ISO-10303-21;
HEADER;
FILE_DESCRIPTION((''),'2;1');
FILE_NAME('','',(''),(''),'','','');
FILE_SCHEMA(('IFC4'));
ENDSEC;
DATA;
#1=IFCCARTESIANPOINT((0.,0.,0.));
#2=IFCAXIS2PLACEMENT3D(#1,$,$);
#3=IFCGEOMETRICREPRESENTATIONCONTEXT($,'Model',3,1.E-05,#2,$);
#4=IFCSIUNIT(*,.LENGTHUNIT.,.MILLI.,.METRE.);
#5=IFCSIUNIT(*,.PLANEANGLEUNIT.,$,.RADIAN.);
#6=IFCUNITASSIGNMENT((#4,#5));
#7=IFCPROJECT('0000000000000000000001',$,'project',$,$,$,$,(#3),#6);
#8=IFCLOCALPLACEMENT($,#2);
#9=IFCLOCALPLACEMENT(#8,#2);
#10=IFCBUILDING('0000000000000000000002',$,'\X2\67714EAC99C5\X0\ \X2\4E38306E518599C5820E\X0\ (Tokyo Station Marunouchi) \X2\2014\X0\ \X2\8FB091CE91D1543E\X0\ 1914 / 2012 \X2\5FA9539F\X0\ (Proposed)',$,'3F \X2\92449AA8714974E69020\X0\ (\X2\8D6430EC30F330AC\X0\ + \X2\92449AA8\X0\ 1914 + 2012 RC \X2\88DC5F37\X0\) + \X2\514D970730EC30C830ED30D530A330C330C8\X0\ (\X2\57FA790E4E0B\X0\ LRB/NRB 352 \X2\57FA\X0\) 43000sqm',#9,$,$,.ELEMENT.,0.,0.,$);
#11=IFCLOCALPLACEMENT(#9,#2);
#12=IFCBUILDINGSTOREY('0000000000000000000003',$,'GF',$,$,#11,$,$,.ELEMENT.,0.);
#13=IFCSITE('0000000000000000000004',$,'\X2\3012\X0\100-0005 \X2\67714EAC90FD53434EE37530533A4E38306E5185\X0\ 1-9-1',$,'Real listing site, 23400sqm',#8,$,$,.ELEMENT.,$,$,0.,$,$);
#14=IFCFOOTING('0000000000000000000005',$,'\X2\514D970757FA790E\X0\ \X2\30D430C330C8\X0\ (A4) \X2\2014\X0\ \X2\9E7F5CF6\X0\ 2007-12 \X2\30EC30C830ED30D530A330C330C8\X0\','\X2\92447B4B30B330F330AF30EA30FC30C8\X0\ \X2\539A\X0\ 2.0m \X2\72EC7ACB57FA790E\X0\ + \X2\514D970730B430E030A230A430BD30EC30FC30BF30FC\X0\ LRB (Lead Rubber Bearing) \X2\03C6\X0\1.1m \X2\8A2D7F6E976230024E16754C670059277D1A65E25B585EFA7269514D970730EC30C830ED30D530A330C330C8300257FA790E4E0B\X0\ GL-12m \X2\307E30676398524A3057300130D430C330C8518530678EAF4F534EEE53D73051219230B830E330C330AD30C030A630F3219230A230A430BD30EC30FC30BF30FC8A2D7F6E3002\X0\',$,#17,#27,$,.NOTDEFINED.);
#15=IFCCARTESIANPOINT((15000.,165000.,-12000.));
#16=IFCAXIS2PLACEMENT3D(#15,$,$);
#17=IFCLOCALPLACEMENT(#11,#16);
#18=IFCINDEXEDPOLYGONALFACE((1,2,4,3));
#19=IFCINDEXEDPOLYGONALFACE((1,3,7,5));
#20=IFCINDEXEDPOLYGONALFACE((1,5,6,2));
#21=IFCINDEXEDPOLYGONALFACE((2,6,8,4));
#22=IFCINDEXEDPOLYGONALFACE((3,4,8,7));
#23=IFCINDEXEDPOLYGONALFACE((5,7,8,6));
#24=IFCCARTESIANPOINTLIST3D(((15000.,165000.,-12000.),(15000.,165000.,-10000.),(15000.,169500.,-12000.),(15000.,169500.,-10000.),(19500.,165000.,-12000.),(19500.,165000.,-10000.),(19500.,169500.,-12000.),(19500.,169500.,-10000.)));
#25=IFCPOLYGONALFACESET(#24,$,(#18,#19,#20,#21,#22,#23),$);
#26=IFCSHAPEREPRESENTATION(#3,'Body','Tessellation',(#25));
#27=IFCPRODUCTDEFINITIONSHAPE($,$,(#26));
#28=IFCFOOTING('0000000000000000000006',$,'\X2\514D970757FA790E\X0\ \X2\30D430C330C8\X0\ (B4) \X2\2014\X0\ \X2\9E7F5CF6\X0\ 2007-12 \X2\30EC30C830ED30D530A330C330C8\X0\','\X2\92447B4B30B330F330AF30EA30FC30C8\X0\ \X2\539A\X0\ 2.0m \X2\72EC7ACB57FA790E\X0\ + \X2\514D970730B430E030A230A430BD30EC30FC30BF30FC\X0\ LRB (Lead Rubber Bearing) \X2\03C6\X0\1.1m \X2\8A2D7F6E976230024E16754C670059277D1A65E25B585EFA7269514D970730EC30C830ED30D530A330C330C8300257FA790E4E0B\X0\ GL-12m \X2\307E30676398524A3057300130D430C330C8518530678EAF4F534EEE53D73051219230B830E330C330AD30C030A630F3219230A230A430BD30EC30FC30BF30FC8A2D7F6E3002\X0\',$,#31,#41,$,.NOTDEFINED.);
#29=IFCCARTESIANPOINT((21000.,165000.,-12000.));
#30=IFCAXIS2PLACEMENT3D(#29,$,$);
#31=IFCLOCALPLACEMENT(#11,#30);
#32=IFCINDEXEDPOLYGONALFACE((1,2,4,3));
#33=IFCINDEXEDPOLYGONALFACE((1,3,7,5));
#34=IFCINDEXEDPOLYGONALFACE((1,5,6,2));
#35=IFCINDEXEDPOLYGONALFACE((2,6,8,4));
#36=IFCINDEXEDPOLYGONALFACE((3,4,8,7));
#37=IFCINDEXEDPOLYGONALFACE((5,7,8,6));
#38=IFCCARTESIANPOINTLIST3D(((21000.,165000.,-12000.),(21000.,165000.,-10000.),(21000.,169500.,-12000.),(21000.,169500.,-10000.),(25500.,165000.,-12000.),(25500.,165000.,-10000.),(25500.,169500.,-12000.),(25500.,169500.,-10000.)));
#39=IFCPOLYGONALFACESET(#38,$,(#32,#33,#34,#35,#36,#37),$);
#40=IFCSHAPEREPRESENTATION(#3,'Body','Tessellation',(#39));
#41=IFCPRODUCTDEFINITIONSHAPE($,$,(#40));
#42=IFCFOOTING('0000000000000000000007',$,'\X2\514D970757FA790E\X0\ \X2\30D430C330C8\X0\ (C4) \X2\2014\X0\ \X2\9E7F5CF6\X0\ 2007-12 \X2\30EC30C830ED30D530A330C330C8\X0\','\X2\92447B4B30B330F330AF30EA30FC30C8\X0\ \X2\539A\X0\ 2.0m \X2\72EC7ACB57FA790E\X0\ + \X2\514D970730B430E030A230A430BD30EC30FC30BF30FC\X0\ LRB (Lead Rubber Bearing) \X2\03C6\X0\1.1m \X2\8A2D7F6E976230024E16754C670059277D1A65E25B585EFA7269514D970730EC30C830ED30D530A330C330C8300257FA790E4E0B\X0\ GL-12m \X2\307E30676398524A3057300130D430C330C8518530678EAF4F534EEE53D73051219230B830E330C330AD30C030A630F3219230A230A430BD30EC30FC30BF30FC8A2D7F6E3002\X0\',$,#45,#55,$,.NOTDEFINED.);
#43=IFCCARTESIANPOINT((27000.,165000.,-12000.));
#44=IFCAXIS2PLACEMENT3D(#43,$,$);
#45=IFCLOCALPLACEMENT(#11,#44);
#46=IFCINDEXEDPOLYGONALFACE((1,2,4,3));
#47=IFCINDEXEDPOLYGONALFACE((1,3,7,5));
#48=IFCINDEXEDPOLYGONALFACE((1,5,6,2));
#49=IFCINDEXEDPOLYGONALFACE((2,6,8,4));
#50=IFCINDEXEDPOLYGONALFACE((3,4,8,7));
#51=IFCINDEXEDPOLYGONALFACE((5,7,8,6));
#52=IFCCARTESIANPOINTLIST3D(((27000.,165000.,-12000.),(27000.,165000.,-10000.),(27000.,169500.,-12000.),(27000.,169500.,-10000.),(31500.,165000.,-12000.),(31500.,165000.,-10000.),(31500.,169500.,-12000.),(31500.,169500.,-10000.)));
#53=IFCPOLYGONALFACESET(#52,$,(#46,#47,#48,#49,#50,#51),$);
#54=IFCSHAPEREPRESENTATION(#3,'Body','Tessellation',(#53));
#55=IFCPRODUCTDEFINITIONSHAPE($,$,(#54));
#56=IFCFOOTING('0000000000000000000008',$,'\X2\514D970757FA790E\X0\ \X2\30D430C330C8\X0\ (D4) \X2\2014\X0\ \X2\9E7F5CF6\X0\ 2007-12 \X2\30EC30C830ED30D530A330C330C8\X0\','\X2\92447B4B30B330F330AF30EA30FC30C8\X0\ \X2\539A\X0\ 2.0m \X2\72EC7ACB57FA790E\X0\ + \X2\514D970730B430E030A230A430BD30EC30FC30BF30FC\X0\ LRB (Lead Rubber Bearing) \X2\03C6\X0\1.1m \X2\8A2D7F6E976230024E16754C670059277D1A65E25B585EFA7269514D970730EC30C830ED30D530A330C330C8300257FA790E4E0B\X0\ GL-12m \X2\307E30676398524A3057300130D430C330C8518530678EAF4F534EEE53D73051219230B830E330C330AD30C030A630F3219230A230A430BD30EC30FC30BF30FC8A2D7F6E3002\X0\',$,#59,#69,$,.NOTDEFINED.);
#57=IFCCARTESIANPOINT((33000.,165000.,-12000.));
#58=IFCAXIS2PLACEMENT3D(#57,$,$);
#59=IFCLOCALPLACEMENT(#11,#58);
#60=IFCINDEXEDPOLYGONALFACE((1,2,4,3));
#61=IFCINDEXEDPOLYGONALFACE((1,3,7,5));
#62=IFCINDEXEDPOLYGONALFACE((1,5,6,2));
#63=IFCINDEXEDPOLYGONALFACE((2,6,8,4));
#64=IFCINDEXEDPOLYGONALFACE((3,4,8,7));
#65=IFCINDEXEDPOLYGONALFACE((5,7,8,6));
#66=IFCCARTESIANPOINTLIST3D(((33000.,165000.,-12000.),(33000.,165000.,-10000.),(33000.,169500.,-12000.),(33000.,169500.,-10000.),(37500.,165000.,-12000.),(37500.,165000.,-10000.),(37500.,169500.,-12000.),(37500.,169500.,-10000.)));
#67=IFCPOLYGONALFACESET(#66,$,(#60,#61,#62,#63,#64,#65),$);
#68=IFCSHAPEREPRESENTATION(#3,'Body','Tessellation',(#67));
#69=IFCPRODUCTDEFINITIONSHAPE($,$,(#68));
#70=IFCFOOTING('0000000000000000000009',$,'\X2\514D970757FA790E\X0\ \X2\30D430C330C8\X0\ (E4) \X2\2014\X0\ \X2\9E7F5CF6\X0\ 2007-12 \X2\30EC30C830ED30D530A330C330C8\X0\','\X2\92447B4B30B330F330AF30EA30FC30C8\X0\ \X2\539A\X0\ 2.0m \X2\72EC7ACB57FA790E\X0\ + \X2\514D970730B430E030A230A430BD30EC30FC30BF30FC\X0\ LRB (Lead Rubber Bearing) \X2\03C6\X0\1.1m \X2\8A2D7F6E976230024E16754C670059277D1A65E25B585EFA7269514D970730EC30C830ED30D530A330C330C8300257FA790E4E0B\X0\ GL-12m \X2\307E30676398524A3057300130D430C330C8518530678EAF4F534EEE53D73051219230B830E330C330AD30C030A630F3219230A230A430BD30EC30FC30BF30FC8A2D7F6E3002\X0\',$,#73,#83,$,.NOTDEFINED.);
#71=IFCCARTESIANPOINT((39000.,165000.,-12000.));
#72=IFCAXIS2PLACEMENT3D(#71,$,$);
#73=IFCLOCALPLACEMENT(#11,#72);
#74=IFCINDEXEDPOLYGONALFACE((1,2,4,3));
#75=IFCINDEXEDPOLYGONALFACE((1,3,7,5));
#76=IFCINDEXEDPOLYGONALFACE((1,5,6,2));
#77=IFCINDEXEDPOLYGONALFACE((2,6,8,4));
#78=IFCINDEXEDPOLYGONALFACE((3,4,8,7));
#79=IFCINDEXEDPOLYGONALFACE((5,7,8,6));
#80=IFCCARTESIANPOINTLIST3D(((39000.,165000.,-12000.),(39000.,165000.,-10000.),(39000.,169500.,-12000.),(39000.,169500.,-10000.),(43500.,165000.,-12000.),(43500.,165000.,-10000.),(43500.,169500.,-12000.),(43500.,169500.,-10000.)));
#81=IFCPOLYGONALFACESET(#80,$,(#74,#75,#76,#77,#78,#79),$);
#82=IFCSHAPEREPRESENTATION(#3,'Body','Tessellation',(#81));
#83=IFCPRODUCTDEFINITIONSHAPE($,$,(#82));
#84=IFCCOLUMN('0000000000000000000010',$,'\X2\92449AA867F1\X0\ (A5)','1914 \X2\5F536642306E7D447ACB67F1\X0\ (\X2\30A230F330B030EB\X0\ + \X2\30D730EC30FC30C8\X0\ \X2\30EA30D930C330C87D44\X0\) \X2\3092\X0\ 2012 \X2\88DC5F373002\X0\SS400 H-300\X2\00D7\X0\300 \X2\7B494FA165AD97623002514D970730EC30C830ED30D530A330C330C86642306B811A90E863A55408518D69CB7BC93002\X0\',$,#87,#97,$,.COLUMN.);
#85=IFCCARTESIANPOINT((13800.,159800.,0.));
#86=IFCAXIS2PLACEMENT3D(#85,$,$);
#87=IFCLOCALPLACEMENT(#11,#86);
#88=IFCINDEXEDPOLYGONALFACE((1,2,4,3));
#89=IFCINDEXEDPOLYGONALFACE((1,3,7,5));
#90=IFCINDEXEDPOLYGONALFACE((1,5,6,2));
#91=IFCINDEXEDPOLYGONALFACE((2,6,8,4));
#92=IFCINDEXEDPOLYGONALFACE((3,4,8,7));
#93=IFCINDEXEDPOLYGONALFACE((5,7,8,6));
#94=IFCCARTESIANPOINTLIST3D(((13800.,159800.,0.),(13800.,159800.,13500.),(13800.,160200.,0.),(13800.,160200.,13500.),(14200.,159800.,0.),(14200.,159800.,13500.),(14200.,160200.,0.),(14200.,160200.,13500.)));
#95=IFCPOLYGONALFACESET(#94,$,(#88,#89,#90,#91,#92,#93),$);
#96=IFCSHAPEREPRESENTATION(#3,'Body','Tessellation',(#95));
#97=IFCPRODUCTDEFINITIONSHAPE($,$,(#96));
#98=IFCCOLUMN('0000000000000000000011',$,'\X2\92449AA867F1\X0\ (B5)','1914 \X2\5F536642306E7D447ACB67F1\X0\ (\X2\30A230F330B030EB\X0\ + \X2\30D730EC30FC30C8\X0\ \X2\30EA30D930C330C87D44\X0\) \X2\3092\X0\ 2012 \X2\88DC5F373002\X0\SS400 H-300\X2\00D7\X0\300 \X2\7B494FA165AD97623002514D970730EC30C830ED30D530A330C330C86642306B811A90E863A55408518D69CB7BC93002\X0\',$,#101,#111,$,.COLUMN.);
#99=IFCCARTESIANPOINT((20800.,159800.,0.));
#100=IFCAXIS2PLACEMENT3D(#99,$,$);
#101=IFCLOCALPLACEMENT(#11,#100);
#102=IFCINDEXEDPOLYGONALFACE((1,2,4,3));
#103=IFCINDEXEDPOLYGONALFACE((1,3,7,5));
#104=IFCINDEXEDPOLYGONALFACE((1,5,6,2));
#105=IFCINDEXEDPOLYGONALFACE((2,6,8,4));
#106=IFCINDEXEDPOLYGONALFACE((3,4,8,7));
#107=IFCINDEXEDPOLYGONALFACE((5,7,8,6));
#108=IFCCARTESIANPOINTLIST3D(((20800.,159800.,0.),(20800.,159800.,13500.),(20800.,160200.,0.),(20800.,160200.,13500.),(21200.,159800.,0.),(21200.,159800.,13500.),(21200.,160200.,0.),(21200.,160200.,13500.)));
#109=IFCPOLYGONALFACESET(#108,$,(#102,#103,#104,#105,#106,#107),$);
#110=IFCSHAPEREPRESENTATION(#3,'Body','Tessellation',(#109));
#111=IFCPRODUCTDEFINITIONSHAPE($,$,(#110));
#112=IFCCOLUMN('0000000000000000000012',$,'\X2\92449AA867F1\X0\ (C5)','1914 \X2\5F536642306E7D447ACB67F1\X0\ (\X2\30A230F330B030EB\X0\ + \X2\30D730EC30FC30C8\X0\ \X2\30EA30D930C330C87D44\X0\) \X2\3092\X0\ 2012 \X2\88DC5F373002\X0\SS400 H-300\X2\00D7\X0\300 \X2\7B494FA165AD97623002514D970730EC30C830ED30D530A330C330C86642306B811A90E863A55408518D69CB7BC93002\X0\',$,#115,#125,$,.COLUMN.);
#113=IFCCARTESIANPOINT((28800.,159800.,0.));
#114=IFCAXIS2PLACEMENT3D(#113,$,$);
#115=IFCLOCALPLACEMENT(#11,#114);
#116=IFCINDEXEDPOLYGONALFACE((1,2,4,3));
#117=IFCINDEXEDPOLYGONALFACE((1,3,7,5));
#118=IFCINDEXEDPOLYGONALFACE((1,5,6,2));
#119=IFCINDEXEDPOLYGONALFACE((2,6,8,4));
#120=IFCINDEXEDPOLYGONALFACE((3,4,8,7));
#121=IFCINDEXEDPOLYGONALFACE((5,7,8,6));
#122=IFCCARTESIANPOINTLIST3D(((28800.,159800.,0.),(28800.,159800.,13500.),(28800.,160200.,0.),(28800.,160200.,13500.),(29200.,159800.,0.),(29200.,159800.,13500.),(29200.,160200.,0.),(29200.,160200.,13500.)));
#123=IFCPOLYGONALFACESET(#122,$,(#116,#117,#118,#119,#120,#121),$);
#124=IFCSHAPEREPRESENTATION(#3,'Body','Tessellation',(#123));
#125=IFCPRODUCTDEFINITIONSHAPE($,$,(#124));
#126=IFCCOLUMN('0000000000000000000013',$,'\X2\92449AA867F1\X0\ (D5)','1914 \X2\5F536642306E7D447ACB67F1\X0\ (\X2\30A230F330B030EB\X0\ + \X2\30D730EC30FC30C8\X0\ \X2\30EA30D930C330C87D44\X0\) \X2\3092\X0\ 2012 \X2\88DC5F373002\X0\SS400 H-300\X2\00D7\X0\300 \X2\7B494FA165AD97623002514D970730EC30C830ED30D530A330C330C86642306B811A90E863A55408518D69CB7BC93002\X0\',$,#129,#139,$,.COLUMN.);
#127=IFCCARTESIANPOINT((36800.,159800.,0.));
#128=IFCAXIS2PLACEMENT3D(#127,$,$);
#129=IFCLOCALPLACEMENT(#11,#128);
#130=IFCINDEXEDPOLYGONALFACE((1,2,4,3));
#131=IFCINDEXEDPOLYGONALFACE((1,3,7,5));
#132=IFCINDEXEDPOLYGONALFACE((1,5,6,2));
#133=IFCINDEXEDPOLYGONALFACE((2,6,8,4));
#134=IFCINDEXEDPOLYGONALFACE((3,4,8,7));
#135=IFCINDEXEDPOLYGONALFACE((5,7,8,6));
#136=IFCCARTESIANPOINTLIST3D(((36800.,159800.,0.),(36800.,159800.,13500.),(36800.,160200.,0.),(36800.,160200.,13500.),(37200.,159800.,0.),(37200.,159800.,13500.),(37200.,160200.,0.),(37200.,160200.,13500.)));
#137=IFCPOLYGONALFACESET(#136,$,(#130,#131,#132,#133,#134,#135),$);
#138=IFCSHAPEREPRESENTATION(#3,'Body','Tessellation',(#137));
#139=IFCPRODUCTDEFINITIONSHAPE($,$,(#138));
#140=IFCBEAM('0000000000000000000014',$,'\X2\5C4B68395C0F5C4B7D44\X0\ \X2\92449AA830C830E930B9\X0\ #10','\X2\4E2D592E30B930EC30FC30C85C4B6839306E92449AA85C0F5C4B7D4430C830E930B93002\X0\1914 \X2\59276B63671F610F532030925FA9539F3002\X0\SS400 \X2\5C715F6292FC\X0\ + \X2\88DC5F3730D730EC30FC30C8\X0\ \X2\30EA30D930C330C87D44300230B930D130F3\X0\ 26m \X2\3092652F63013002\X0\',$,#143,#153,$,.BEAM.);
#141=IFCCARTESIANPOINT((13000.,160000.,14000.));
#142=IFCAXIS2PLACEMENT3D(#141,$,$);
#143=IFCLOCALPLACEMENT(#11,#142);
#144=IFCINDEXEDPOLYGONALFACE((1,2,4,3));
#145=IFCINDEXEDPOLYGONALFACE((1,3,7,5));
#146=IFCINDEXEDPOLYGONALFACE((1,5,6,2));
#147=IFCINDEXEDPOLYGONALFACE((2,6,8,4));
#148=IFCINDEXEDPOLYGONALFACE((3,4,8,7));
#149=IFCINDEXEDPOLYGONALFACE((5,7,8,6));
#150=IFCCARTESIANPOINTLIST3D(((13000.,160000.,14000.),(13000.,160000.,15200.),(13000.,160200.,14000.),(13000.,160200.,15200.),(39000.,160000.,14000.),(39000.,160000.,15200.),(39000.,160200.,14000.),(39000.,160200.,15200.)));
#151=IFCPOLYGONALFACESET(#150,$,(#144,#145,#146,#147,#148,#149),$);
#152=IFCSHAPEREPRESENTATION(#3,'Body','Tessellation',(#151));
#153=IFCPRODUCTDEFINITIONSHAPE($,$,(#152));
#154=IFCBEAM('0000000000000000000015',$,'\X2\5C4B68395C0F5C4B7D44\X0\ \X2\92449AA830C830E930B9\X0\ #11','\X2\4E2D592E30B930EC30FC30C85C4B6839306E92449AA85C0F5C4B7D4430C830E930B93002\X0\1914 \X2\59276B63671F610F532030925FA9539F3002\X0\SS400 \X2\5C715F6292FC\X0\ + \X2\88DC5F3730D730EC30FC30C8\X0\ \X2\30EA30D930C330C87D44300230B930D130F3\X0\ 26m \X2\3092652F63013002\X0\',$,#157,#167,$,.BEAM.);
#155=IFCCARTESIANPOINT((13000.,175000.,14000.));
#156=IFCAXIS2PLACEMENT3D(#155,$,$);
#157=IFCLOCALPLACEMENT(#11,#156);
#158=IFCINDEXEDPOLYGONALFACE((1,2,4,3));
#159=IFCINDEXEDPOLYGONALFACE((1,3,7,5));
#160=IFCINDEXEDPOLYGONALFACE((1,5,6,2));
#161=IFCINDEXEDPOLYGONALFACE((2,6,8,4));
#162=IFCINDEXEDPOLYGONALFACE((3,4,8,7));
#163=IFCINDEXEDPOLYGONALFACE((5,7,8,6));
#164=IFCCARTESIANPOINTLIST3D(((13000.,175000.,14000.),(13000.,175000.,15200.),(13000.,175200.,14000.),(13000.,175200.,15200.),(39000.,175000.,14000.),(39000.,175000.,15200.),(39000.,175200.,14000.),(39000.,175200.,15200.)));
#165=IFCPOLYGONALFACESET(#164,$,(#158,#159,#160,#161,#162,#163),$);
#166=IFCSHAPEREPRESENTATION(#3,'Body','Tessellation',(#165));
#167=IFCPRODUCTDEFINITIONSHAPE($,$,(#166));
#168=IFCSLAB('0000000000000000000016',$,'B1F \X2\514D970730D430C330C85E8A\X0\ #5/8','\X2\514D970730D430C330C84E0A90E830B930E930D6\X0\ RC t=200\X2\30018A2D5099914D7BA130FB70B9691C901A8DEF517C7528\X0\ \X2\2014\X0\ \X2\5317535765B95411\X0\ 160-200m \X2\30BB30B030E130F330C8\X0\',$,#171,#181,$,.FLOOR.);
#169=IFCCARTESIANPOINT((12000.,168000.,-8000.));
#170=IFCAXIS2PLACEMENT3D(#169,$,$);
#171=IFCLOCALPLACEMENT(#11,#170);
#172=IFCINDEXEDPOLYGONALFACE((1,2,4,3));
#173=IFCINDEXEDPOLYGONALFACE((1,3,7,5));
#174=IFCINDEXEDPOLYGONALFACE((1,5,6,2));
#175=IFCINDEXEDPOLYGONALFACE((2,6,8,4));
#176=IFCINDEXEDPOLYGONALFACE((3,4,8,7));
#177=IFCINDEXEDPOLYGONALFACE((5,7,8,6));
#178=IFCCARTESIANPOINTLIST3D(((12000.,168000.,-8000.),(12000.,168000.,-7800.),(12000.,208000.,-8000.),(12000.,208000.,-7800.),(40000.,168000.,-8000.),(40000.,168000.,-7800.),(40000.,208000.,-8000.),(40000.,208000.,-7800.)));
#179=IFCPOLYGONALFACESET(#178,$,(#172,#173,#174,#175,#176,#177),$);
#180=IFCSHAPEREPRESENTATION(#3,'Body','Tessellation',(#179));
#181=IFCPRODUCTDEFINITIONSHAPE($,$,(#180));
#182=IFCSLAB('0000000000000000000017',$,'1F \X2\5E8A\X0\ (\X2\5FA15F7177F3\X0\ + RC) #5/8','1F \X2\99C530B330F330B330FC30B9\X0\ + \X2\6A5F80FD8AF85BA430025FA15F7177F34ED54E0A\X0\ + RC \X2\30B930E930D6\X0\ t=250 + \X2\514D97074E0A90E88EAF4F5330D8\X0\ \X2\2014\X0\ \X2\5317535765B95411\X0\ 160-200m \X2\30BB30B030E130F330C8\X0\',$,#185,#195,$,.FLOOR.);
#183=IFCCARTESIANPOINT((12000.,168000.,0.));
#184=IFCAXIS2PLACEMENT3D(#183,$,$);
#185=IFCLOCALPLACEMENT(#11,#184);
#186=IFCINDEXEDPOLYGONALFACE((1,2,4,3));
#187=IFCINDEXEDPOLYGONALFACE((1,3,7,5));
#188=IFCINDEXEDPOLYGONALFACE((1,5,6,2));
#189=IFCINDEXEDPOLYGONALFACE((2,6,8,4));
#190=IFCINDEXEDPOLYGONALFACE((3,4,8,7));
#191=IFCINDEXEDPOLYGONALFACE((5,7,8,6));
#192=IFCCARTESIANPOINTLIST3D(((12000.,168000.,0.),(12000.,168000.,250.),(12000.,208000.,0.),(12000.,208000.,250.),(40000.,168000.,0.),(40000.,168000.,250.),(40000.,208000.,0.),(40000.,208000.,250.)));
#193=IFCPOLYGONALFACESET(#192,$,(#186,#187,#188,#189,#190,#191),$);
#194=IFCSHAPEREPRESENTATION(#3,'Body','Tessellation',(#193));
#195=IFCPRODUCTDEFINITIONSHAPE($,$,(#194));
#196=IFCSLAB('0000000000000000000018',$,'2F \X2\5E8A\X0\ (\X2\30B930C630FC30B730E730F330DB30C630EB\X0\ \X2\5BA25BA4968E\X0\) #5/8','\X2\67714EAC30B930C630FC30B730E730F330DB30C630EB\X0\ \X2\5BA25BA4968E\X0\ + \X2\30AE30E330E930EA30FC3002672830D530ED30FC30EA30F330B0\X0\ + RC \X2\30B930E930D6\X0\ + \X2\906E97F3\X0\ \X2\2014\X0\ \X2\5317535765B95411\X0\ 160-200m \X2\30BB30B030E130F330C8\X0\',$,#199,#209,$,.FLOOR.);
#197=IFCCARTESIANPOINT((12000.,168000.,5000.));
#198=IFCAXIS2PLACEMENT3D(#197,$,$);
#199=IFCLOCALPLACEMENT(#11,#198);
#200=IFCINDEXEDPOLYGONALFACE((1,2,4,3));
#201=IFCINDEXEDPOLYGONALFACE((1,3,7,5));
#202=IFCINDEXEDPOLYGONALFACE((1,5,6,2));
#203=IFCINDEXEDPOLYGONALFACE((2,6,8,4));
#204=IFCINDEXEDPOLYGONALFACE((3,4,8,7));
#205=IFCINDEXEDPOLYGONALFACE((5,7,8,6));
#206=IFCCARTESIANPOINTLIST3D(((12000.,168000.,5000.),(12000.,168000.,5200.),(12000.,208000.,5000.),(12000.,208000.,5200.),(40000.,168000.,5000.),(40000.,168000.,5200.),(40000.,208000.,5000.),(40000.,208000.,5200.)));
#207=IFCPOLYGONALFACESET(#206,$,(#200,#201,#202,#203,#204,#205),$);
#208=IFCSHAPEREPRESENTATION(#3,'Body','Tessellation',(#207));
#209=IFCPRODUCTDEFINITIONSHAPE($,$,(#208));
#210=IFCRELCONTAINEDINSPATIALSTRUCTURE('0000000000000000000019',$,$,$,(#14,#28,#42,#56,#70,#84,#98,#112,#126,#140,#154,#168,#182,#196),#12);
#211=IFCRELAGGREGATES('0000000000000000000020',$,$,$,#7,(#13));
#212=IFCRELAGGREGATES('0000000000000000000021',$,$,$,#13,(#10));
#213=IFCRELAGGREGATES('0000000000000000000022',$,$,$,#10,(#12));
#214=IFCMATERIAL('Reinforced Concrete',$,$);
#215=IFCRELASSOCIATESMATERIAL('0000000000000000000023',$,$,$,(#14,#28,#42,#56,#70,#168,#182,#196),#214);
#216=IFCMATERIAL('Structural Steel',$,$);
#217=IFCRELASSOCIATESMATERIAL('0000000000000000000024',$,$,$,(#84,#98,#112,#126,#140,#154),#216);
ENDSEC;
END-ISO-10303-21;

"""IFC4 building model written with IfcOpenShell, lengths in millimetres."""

from ifc_helpers import new_model, si_unit, frame, frame_2d, origin, place, context, project, spatial, rectangle, extrude, material, element, save


model = new_model("IFC4")

# Units and contexts
model_context = context("Model", 3, precision=1e-05, world=origin())
ifc_project = project(units=[si_unit("LENGTHUNIT", "METRE", prefix="MILLI"), si_unit("PLANEANGLEUNIT", "RADIAN")], contexts=[model_context])

# Site, building, storey
site_placement = place(None, origin())
site = spatial("IfcSite", under=ifc_project, at=site_placement, Name="〒100-0005 東京都千代田区丸の内 1-9-1", ObjectType="Real listing site, 23400sqm", CompositionType="ELEMENT", RefElevation=0.0)
building_placement = place(site_placement, origin())
building = spatial("IfcBuilding", under=site, at=building_placement, Name="東京駅 丸の内駅舎 (Tokyo Station Marunouchi) — 辰野金吾 1914 / 2012 復原 (Proposed)", ObjectType="3F 鉄骨煉瓦造 (赤レンガ + 鉄骨 1914 + 2012 RC 補強) + 免震レトロフィット (基礎下 LRB/NRB 352 基) 43000sqm", CompositionType="ELEMENT", ElevationOfRefHeight=0.0, ElevationOfTerrain=0.0)
storey_placement = place(building_placement, origin())
storey = spatial("IfcBuildingStorey", under=building, at=storey_placement, Name="GF", CompositionType="ELEMENT", Elevation=0.0)

# Footings
ifc_material_1 = material(Name="Reinforced Concrete")
footing_1_placement = place(storey_placement, frame((15000.0, 165000.0, -12000.0)))
element("IfcFooting", 1, at=footing_1_placement, inside=storey, material=ifc_material_1, Name="免震基礎 ピット (A4) — 鹿島 2007-12 レトロフィット", Description="鉄筋コンクリート 厚 2.0m 独立基礎 + 免震ゴムアイソレーター LRB (Lead Rubber Bearing) φ1.1m 設置面。世界最大級既存建物免震レトロフィット。基礎下 GL-12m まで掘削し、ピット内で躯体仮受け→ジャッキダウン→アイソレーター設置。", PredefinedType="NOTDEFINED", context=model_context, shape_type="SweptSolid", body=[
    extrude(rectangle(XDim=4500.0, YDim=4500.0, at=frame_2d((2250.0, 2250.0))), frame((15000.0, 165000.0, -12000.0)), (0.0, 0.0, 1.0), 2000.0),
])
footing_2_placement = place(storey_placement, frame((21000.0, 165000.0, -12000.0)))
element("IfcFooting", 2, at=footing_2_placement, inside=storey, material=ifc_material_1, Name="免震基礎 ピット (B4) — 鹿島 2007-12 レトロフィット", Description="鉄筋コンクリート 厚 2.0m 独立基礎 + 免震ゴムアイソレーター LRB (Lead Rubber Bearing) φ1.1m 設置面。世界最大級既存建物免震レトロフィット。基礎下 GL-12m まで掘削し、ピット内で躯体仮受け→ジャッキダウン→アイソレーター設置。", PredefinedType="NOTDEFINED", context=model_context, shape_type="SweptSolid", body=[
    extrude(rectangle(XDim=4500.0, YDim=4500.0, at=frame_2d((2250.0, 2250.0))), frame((21000.0, 165000.0, -12000.0)), (0.0, 0.0, 1.0), 2000.0),
])
footing_3_placement = place(storey_placement, frame((27000.0, 165000.0, -12000.0)))
element("IfcFooting", 3, at=footing_3_placement, inside=storey, material=ifc_material_1, Name="免震基礎 ピット (C4) — 鹿島 2007-12 レトロフィット", Description="鉄筋コンクリート 厚 2.0m 独立基礎 + 免震ゴムアイソレーター LRB (Lead Rubber Bearing) φ1.1m 設置面。世界最大級既存建物免震レトロフィット。基礎下 GL-12m まで掘削し、ピット内で躯体仮受け→ジャッキダウン→アイソレーター設置。", PredefinedType="NOTDEFINED", context=model_context, shape_type="SweptSolid", body=[
    extrude(rectangle(XDim=4500.0, YDim=4500.0, at=frame_2d((2250.0, 2250.0))), frame((27000.0, 165000.0, -12000.0)), (0.0, 0.0, 1.0), 2000.0),
])
footing_4_placement = place(storey_placement, frame((33000.0, 165000.0, -12000.0)))
element("IfcFooting", 4, at=footing_4_placement, inside=storey, material=ifc_material_1, Name="免震基礎 ピット (D4) — 鹿島 2007-12 レトロフィット", Description="鉄筋コンクリート 厚 2.0m 独立基礎 + 免震ゴムアイソレーター LRB (Lead Rubber Bearing) φ1.1m 設置面。世界最大級既存建物免震レトロフィット。基礎下 GL-12m まで掘削し、ピット内で躯体仮受け→ジャッキダウン→アイソレーター設置。", PredefinedType="NOTDEFINED", context=model_context, shape_type="SweptSolid", body=[
    extrude(rectangle(XDim=4500.0, YDim=4500.0, at=frame_2d((2250.0, 2250.0))), frame((33000.0, 165000.0, -12000.0)), (0.0, 0.0, 1.0), 2000.0),
])
footing_5_placement = place(storey_placement, frame((39000.0, 165000.0, -12000.0)))
element("IfcFooting", 5, at=footing_5_placement, inside=storey, material=ifc_material_1, Name="免震基礎 ピット (E4) — 鹿島 2007-12 レトロフィット", Description="鉄筋コンクリート 厚 2.0m 独立基礎 + 免震ゴムアイソレーター LRB (Lead Rubber Bearing) φ1.1m 設置面。世界最大級既存建物免震レトロフィット。基礎下 GL-12m まで掘削し、ピット内で躯体仮受け→ジャッキダウン→アイソレーター設置。", PredefinedType="NOTDEFINED", context=model_context, shape_type="SweptSolid", body=[
    extrude(rectangle(XDim=4500.0, YDim=4500.0, at=frame_2d((2250.0, 2250.0))), frame((39000.0, 165000.0, -12000.0)), (0.0, 0.0, 1.0), 2000.0),
])

# Columns
ifc_material_2 = material(Name="Structural Steel")
column_1_placement = place(storey_placement, frame((13800.0, 159800.0, 0.0)))
element("IfcColumn", 6, at=column_1_placement, inside=storey, material=ifc_material_2, Name="鉄骨柱 (A5)", Description="1914 当時の組立柱 (アングル + プレート リベット組) を 2012 補強。SS400 H-300×300 等価断面。免震レトロフィット時に脚部接合再構築。", PredefinedType="COLUMN", context=model_context, shape_type="SweptSolid", body=[
    extrude(rectangle(XDim=400.0, YDim=400.0, at=frame_2d((200.0, 200.0))), frame((13800.0, 159800.0, 0.0)), (0.0, 0.0, 1.0), 13500.0),
])
column_2_placement = place(storey_placement, frame((20800.0, 159800.0, 0.0)))
element("IfcColumn", 7, at=column_2_placement, inside=storey, material=ifc_material_2, Name="鉄骨柱 (B5)", Description="1914 当時の組立柱 (アングル + プレート リベット組) を 2012 補強。SS400 H-300×300 等価断面。免震レトロフィット時に脚部接合再構築。", PredefinedType="COLUMN", context=model_context, shape_type="SweptSolid", body=[
    extrude(rectangle(XDim=400.0, YDim=400.0, at=frame_2d((200.0, 200.0))), frame((20800.0, 159800.0, 0.0)), (0.0, 0.0, 1.0), 13500.0),
])
column_3_placement = place(storey_placement, frame((28800.0, 159800.0, 0.0)))
element("IfcColumn", 8, at=column_3_placement, inside=storey, material=ifc_material_2, Name="鉄骨柱 (C5)", Description="1914 当時の組立柱 (アングル + プレート リベット組) を 2012 補強。SS400 H-300×300 等価断面。免震レトロフィット時に脚部接合再構築。", PredefinedType="COLUMN", context=model_context, shape_type="SweptSolid", body=[
    extrude(rectangle(XDim=400.0, YDim=400.0, at=frame_2d((200.0, 200.0))), frame((28800.0, 159800.0, 0.0)), (0.0, 0.0, 1.0), 13500.0),
])
column_4_placement = place(storey_placement, frame((36800.0, 159800.0, 0.0)))
element("IfcColumn", 9, at=column_4_placement, inside=storey, material=ifc_material_2, Name="鉄骨柱 (D5)", Description="1914 当時の組立柱 (アングル + プレート リベット組) を 2012 補強。SS400 H-300×300 等価断面。免震レトロフィット時に脚部接合再構築。", PredefinedType="COLUMN", context=model_context, shape_type="SweptSolid", body=[
    extrude(rectangle(XDim=400.0, YDim=400.0, at=frame_2d((200.0, 200.0))), frame((36800.0, 159800.0, 0.0)), (0.0, 0.0, 1.0), 13500.0),
])

# Beams
beam_1_placement = place(storey_placement, frame((13000.0, 160000.0, 14000.0)))
element("IfcBeam", 10, at=beam_1_placement, inside=storey, material=ifc_material_2, Name="屋根小屋組 鉄骨トラス #10", Description="中央スレート屋根の鉄骨小屋組トラス。1914 大正期意匠を復原。SS400 山形鋼 + 補強プレート リベット組。スパン 26m を支持。", PredefinedType="BEAM", context=model_context, shape_type="SweptSolid", body=[
    extrude(rectangle(XDim=26000.0, YDim=200.0, at=frame_2d((13000.0, 100.0))), frame((13000.0, 160000.0, 14000.0)), (0.0, 0.0, 1.0), 1200.0),
])
beam_2_placement = place(storey_placement, frame((13000.0, 175000.0, 14000.0)))
element("IfcBeam", 11, at=beam_2_placement, inside=storey, material=ifc_material_2, Name="屋根小屋組 鉄骨トラス #11", Description="中央スレート屋根の鉄骨小屋組トラス。1914 大正期意匠を復原。SS400 山形鋼 + 補強プレート リベット組。スパン 26m を支持。", PredefinedType="BEAM", context=model_context, shape_type="SweptSolid", body=[
    extrude(rectangle(XDim=26000.0, YDim=200.0, at=frame_2d((13000.0, 100.0))), frame((13000.0, 175000.0, 14000.0)), (0.0, 0.0, 1.0), 1200.0),
])

# Slabs
slab_1_placement = place(storey_placement, frame((12000.0, 168000.0, -8000.0)))
element("IfcSlab", 12, at=slab_1_placement, inside=storey, material=ifc_material_1, Name="B1F 免震ピット床 #5/8", Description="免震ピット上部スラブ RC t=200、設備配管・点検通路兼用 — 北南方向 160-200m セグメント", PredefinedType="FLOOR", context=model_context, shape_type="SweptSolid", body=[
    extrude(rectangle(XDim=28000.0, YDim=40000.0, at=frame_2d((14000.0, 20000.0))), frame((12000.0, 168000.0, -8000.0)), (0.0, 0.0, 1.0), 200.0),
])
slab_2_placement = place(storey_placement, frame((12000.0, 168000.0, 0.0)))
element("IfcSlab", 13, at=slab_2_placement, inside=storey, material=ifc_material_1, Name="1F 床 (御影石 + RC) #5/8", Description="1F 駅コンコース + 機能諸室。御影石仕上 + RC スラブ t=250 + 免震上部躯体ヘ — 北南方向 160-200m セグメント", PredefinedType="FLOOR", context=model_context, shape_type="SweptSolid", body=[
    extrude(rectangle(XDim=28000.0, YDim=40000.0, at=frame_2d((14000.0, 20000.0))), frame((12000.0, 168000.0, 0.0)), (0.0, 0.0, 1.0), 250.0),
])
slab_3_placement = place(storey_placement, frame((12000.0, 168000.0, 5000.0)))
element("IfcSlab", 14, at=slab_3_placement, inside=storey, material=ifc_material_1, Name="2F 床 (ステーションホテル 客室階) #5/8", Description="東京ステーションホテル 客室階 + ギャラリー。木フローリング + RC スラブ + 遮音 — 北南方向 160-200m セグメント", PredefinedType="FLOOR", context=model_context, shape_type="SweptSolid", body=[
    extrude(rectangle(XDim=28000.0, YDim=40000.0, at=frame_2d((14000.0, 20000.0))), frame((12000.0, 168000.0, 5000.0)), (0.0, 0.0, 1.0), 200.0),
])

save(model, "model.ifc")
